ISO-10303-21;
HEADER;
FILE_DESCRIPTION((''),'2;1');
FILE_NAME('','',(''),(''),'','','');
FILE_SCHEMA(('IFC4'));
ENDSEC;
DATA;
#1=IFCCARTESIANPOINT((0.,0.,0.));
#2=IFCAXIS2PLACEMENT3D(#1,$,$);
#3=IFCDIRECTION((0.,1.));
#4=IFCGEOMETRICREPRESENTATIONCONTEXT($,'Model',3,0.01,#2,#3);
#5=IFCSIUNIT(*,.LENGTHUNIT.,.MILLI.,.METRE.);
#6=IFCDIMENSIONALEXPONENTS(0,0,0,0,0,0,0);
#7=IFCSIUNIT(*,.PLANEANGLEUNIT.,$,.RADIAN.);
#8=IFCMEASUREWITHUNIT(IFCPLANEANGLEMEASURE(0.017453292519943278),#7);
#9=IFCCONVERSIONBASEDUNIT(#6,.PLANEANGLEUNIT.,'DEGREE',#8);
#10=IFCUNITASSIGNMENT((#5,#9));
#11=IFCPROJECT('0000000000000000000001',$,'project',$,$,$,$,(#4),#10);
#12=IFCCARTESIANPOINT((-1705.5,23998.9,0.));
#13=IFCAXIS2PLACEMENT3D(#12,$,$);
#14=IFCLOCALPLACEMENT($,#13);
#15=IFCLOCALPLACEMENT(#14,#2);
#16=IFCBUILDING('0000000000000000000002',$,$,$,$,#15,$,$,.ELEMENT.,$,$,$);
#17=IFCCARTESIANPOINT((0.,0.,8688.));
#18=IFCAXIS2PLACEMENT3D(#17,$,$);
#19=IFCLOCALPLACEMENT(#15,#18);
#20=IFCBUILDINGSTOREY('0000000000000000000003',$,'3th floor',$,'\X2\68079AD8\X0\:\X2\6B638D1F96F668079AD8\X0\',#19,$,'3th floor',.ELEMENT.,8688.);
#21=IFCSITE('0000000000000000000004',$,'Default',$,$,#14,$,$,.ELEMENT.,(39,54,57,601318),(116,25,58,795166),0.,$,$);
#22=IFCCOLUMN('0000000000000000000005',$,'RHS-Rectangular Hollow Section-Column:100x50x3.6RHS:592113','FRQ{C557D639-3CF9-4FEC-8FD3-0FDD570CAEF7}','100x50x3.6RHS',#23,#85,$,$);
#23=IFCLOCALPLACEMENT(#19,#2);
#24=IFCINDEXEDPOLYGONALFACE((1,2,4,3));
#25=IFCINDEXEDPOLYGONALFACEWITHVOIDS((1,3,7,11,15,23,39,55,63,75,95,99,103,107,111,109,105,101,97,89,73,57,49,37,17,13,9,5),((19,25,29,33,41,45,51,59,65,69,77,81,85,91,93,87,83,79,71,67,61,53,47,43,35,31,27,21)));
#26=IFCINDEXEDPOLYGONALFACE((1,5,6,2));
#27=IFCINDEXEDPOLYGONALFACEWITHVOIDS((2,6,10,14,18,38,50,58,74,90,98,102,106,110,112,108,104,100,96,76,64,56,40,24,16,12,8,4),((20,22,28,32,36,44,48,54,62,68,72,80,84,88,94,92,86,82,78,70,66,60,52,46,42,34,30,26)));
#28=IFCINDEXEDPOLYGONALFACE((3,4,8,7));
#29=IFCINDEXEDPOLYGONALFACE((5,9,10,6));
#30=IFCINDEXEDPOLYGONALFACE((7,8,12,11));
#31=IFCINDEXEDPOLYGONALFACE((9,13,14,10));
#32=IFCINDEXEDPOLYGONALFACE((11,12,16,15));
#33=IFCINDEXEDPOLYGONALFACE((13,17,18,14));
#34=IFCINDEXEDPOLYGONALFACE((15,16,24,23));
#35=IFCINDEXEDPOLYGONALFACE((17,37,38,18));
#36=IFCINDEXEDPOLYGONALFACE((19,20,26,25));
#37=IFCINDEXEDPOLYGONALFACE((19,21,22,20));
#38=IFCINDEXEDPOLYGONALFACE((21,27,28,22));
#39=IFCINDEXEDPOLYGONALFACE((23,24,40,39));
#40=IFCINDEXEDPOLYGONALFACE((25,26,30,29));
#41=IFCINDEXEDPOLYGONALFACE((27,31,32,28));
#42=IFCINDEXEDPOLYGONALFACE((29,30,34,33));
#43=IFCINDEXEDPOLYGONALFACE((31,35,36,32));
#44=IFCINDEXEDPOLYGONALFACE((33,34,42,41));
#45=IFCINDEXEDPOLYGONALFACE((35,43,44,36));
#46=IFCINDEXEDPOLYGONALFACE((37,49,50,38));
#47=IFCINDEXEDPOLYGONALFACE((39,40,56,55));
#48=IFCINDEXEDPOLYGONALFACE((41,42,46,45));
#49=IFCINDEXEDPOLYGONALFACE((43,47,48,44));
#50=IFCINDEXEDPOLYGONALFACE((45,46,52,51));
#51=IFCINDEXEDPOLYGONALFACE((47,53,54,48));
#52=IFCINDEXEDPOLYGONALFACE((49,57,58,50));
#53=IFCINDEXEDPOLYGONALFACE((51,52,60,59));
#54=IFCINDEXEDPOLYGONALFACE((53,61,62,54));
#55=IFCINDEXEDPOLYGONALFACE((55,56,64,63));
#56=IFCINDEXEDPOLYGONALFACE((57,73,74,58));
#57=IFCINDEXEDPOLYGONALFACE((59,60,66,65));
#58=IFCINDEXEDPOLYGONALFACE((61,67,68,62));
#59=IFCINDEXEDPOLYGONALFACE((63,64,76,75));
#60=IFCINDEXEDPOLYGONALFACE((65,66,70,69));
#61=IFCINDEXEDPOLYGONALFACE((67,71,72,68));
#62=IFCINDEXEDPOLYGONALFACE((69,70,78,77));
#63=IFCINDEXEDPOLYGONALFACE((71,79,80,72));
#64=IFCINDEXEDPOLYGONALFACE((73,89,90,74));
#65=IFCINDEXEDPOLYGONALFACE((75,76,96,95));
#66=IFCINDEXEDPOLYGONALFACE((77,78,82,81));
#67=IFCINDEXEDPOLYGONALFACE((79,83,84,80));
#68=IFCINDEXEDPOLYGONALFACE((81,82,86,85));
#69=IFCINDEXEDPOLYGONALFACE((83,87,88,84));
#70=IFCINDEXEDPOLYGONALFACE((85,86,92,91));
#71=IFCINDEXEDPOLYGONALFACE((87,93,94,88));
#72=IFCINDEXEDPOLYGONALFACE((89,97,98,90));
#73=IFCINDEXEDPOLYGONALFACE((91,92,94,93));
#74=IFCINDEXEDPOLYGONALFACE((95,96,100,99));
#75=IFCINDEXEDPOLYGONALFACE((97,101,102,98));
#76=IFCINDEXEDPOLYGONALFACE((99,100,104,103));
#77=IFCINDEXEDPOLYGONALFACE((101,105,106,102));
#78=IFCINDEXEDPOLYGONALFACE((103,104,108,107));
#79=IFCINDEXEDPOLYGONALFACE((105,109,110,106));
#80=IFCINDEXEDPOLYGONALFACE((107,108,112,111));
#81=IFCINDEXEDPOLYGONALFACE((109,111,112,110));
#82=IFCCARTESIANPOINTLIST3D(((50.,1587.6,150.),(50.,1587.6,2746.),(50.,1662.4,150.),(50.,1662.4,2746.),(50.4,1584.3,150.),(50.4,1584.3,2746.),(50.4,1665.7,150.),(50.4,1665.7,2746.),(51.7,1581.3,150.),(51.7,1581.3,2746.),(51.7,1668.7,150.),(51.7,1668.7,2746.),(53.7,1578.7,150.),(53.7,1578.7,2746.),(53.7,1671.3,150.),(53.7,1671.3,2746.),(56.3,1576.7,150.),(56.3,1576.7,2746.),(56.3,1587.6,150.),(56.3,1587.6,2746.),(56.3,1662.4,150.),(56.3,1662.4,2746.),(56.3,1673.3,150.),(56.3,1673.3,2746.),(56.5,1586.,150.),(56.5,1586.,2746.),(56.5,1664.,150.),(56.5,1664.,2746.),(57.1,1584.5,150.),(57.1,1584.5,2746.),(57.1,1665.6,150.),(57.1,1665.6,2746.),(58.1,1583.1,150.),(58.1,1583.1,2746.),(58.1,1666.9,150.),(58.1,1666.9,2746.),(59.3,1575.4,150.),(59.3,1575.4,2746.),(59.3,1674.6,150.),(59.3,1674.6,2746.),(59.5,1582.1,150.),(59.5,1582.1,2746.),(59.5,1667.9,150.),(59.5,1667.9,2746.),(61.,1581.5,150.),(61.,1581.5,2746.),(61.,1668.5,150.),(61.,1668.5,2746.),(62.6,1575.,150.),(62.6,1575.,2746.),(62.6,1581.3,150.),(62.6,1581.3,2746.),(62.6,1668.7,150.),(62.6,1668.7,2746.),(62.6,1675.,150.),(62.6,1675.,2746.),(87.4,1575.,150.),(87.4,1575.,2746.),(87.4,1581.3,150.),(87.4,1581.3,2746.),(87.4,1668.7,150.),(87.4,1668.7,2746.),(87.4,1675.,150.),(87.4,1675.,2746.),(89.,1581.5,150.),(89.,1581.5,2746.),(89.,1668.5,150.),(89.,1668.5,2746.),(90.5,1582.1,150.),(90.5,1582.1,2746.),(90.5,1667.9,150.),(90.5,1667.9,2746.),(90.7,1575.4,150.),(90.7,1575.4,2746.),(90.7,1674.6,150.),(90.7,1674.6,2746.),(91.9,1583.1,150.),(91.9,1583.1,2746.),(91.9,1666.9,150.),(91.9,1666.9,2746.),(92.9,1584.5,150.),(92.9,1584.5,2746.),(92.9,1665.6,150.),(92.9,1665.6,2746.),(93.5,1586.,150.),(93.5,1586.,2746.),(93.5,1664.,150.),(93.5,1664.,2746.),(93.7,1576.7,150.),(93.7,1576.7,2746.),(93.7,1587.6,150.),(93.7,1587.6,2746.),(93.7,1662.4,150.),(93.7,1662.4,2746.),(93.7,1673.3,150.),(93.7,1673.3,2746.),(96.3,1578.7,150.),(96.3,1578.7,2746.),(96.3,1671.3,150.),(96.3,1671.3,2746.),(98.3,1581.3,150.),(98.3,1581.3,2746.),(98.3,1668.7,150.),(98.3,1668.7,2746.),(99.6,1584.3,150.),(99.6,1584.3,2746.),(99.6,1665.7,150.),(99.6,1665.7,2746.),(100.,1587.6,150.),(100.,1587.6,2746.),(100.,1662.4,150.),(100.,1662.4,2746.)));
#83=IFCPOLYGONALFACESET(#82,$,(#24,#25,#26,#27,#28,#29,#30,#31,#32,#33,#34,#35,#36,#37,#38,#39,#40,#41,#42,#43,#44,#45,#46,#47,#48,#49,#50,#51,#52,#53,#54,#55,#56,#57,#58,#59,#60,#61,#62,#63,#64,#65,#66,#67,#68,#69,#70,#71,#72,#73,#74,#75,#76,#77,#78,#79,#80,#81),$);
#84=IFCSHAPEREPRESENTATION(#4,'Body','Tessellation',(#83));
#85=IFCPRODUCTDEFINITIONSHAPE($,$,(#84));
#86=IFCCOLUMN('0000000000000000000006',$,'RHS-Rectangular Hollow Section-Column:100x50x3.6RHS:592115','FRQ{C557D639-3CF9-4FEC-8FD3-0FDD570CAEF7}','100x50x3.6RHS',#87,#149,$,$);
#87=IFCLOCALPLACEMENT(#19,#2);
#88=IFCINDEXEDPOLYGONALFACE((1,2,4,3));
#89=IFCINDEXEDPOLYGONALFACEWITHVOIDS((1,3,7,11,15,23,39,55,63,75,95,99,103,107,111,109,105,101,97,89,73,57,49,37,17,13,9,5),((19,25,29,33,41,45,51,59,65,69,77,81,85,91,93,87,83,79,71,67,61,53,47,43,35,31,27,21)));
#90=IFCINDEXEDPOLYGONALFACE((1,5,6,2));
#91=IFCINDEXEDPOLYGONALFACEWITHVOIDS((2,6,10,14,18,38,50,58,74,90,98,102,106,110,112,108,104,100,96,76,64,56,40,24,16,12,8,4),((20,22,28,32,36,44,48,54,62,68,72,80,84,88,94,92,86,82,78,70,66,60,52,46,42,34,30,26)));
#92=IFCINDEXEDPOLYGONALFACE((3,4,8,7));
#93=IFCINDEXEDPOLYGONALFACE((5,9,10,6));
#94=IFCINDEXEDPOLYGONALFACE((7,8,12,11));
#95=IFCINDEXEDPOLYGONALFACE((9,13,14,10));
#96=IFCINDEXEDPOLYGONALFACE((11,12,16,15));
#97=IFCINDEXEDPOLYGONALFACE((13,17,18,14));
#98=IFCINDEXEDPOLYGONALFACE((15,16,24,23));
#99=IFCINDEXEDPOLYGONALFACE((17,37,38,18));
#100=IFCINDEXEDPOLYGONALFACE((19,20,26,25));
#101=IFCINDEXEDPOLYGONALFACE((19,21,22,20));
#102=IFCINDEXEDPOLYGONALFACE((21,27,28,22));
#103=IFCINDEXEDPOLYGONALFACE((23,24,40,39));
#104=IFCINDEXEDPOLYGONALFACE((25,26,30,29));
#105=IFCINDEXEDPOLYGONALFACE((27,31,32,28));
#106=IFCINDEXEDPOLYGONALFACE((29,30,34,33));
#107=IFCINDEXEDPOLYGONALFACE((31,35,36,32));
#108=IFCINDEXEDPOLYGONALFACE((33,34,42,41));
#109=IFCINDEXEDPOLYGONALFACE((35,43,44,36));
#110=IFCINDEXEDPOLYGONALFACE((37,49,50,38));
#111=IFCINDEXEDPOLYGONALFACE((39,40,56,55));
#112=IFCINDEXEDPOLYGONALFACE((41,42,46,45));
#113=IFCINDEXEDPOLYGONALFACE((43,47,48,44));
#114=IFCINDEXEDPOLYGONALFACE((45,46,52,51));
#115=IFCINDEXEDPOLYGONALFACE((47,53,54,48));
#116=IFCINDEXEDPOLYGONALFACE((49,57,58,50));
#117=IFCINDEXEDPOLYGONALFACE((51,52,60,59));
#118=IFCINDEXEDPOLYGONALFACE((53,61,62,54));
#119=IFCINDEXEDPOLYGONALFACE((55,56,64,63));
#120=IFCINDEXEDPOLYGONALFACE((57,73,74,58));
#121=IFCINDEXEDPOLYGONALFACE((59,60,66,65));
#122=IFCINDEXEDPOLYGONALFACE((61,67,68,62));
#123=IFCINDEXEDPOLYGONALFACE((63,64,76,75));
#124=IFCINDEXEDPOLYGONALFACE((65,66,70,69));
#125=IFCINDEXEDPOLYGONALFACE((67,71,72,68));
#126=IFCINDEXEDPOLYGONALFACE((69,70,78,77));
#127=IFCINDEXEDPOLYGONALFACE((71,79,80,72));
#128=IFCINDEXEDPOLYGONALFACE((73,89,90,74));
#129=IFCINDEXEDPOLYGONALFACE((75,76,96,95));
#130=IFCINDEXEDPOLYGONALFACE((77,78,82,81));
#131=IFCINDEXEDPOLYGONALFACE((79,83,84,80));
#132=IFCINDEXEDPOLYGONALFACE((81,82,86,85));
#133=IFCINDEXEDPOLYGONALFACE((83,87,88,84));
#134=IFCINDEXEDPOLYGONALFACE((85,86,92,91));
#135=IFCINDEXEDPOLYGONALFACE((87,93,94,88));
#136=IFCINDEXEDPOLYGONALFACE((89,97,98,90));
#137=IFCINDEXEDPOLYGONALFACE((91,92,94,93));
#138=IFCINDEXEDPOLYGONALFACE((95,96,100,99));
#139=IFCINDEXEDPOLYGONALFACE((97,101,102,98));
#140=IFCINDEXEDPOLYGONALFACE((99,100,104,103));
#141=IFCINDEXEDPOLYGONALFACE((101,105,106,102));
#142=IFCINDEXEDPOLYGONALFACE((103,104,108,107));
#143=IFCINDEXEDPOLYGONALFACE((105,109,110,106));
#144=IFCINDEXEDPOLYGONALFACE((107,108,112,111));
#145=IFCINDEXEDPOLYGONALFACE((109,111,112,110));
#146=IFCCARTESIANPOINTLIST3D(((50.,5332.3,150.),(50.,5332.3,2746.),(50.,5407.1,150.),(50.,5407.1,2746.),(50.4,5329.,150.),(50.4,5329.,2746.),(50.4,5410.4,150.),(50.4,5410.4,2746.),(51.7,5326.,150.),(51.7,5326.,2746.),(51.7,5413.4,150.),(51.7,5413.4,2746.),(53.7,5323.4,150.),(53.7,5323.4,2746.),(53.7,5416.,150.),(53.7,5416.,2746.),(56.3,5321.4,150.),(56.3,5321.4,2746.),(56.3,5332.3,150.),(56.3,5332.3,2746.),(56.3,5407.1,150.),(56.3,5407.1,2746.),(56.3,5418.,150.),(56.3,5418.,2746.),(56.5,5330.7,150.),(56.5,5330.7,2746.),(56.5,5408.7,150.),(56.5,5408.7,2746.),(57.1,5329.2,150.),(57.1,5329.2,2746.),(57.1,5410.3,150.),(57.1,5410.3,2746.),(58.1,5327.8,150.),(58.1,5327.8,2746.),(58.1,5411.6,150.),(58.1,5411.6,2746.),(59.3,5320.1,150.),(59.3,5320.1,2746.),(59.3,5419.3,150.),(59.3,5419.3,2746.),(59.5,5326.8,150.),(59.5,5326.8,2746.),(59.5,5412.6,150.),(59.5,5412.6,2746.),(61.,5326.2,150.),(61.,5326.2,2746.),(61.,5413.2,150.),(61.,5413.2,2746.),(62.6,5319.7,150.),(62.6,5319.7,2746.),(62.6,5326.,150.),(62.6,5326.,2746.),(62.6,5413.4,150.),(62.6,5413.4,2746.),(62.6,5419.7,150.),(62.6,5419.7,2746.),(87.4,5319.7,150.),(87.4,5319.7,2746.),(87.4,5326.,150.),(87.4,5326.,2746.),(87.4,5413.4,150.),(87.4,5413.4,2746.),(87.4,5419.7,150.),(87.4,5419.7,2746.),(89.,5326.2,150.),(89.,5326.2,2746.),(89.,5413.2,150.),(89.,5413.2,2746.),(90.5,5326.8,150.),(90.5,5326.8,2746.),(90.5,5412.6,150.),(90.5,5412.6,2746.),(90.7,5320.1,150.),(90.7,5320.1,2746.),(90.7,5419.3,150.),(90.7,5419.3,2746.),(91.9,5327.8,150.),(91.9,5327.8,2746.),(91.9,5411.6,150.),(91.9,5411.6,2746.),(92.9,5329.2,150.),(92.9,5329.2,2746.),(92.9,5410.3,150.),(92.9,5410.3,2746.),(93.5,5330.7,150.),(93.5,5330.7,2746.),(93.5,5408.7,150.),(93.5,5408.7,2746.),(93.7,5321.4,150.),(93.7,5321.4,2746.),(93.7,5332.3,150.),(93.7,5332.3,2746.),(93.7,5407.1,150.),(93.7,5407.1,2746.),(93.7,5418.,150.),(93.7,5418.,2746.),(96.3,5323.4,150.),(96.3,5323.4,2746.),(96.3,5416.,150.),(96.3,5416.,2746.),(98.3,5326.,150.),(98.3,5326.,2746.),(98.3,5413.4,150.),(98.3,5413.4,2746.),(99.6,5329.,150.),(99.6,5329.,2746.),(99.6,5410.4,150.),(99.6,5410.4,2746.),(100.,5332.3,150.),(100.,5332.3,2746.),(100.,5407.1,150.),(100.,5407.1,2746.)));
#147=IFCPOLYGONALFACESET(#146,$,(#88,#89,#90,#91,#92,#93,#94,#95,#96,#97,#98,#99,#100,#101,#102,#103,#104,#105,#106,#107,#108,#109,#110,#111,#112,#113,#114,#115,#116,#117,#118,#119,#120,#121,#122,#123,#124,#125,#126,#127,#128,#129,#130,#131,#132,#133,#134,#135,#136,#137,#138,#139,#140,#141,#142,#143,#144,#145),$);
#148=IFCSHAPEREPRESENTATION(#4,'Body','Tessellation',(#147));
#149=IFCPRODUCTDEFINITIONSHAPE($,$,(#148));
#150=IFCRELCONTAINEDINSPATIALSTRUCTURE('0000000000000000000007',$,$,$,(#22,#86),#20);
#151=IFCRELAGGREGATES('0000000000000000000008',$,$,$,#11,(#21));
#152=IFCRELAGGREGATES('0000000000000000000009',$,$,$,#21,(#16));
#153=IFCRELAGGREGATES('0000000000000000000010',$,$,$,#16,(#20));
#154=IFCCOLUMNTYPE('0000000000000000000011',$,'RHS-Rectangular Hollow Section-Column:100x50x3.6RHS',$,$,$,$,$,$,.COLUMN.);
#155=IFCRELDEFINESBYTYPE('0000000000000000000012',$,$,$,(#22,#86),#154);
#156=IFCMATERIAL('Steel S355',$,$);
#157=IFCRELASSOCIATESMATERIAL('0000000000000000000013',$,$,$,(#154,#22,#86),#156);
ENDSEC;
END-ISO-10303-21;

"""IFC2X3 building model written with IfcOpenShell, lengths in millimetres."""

from ifc_helpers import new_model, entity, si_unit, converted_unit, point, direction, frame, frame_2d, origin, origin_2d, place, context, project, spatial, circle_curve, line_curve, trimmed, segment, composite_curve, hollow_rectangle, outline, extrude, clip, halfspace, material, type_object, element, save


model = new_model("IFC2X3")

# Units and contexts
model_context = context("Model", 3, precision=0.01, world=origin(), true_north=direction((0.0, 1.0)))
ifc_project = project(units=[si_unit("LENGTHUNIT", "METRE", prefix="MILLI"), converted_unit("PLANEANGLEUNIT", "DEGREE", entity("IfcPlaneAngleMeasure", 0.017453292519943278), si_unit("PLANEANGLEUNIT", "RADIAN"), dimensions=[0, 0, 0, 0, 0, 0, 0])], contexts=[model_context])

# Site, building, storey
site_placement = place(None, frame((-1705.5, 23998.9, 0.0)))
site = spatial("IfcSite", under=ifc_project, at=site_placement, Name="Default", CompositionType="ELEMENT", RefLatitude=(39, 54, 57, 601318), RefLongitude=(116, 25, 58, 795166), RefElevation=0.0)
building_placement = place(site_placement, origin())
building = spatial("IfcBuilding", under=site, at=building_placement, CompositionType="ELEMENT")
storey_placement = place(building_placement, frame((0.0, 0.0, 8688.0)))
storey = spatial("IfcBuildingStorey", under=building, at=storey_placement, Name="3th floor", ObjectType="标高:正负零标高", LongName="3th floor", CompositionType="ELEMENT", Elevation=8688.0)

# Columns, openings
ifc_material_1 = material(Name="Steel S355")
column_type_1 = type_object("IfcColumnType", Name="RHS-Rectangular Hollow Section-Column:100x50x3.6RHS", PredefinedType="COLUMN", material=ifc_material_1)
column_1_placement = place(storey_placement, frame((75.0, 1625.0, 2876.9)))
column_1 = element("IfcColumn", 1, at=column_1_placement, inside=storey, type_object=column_type_1, material=ifc_material_1, Name="RHS-Rectangular Hollow Section-Column:100x50x3.6RHS:592113", Description="FRQ{C557D639-3CF9-4FEC-8FD3-0FDD570CAEF7}", ObjectType="100x50x3.6RHS", context=model_context, shape_type="Clipping", body=[
    clip(clip(extrude(hollow_rectangle(XDim=50.0, YDim=100.0, WallThickness=6.3, InnerFilletRadius=6.3, OuterFilletRadius=12.6, at=origin_2d()), origin(), (0.0, 0.0, -1.0), 2782.8), halfspace(frame((-75.0, -1625.0, -2726.9), z_axis=(0.0, 0.0, 1.0), x_axis=(1.0, 0.0, 0.0)), True)), halfspace(frame((-75.0, -1625.0, -55.9), z_axis=(0.0, 0.0, -1.0), x_axis=(-1.0, 0.0, 0.0)), True)),
])
opening_1_placement = place(column_1_placement, frame((0.0, -150.1, -130.9), z_axis=(0.0, 1.0, 0.0), x_axis=(-1.0, 0.0, 0.0)))
element("IfcOpeningElement", 2, at=opening_1_placement, cuts=column_1, ObjectType="Opening", context=model_context, shape_type="SweptSolid", body=[
    extrude(outline(composite_curve([segment(trimmed(circle_curve(frame_2d((43.0, 32.0), x_axis=(1.0, 0.0)), 32.0), [point((43.0, 0.0))], [point((75.0, 32.0))], True, "CARTESIAN"), True, "CONTINUOUS"), segment(trimmed(line_curve((75.0, 32.0), (0.0, 1.0), 86.0), [point((75.0, 32.0))], [point((75.0, 118.0))], True, "CARTESIAN"), True, "CONTINUOUS"), segment(trimmed(circle_curve(frame_2d((43.0, 118.0), x_axis=(1.0, 0.0)), 32.0), [point((75.0, 118.0))], [point((43.0, 150.0))], True, "CARTESIAN"), True, "CONTINUOUS"), segment(trimmed(line_curve((43.0, 150.0), (-1.0, 0.0), 86.0), [point((43.0, 150.0))], [point((-43.0, 150.0))], True, "CARTESIAN"), True, "CONTINUOUS"), segment(trimmed(circle_curve(frame_2d((-43.0, 118.0), x_axis=(1.0, 0.0)), 32.0), [point((-43.0, 150.0))], [point((-75.0, 118.0))], True, "CARTESIAN"), True, "CONTINUOUS"), segment(trimmed(line_curve((-75.0, 118.0), (0.0, -1.0), 86.0), [point((-75.0, 118.0))], [point((-75.0, 32.0))], True, "CARTESIAN"), True, "CONTINUOUS"), segment(trimmed(circle_curve(frame_2d((-43.0, 32.0), x_axis=(1.0, 0.0)), 32.0), [point((-75.0, 32.0))], [point((-43.0, 0.0))], True, "CARTESIAN"), True, "CONTINUOUS"), segment(trimmed(line_curve((-43.0, 0.0), (1.0, 0.0), 86.0), [point((-43.0, 0.0))], [point((43.0, 0.0))], True, "CARTESIAN"), True, "CONTINUOUS")], self_intersect="UNKNOWN")), origin(), (0.0, 0.0, 1.0), 300.2),
])
column_2_placement = place(storey_placement, frame((75.0, 5369.7, 2876.9)))
column_2 = element("IfcColumn", 3, at=column_2_placement, inside=storey, type_object=column_type_1, material=ifc_material_1, Name="RHS-Rectangular Hollow Section-Column:100x50x3.6RHS:592115", Description="FRQ{C557D639-3CF9-4FEC-8FD3-0FDD570CAEF7}", ObjectType="100x50x3.6RHS", context=model_context, shape_type="Clipping", body=[
    clip(clip(extrude(hollow_rectangle(XDim=50.0, YDim=100.0, WallThickness=6.3, InnerFilletRadius=6.3, OuterFilletRadius=12.6, at=origin_2d()), origin(), (0.0, 0.0, -1.0), 2782.8), halfspace(frame((-75.0, -5369.7, -55.9), z_axis=(0.0, 0.0, -1.0), x_axis=(-1.0, 0.0, 0.0)), True)), halfspace(frame((-75.0, -5369.7, -2726.9), z_axis=(0.0, 0.0, 1.0), x_axis=(1.0, 0.0, 0.0)), True)),
])
opening_2_placement = place(column_2_placement, frame((0.0, -150.1, -130.9), z_axis=(0.0, 1.0, 0.0), x_axis=(-1.0, 0.0, 0.0)))
element("IfcOpeningElement", 4, at=opening_2_placement, cuts=column_2, ObjectType="Opening", context=model_context, shape_type="SweptSolid", body=[
    extrude(outline(composite_curve([segment(trimmed(circle_curve(frame_2d((43.0, 32.0), x_axis=(1.0, 0.0)), 32.0), [point((43.0, 0.0))], [point((75.0, 32.0))], True, "CARTESIAN"), True, "CONTINUOUS"), segment(trimmed(line_curve((75.0, 32.0), (0.0, 1.0), 86.0), [point((75.0, 32.0))], [point((75.0, 118.0))], True, "CARTESIAN"), True, "CONTINUOUS"), segment(trimmed(circle_curve(frame_2d((43.0, 118.0), x_axis=(1.0, 0.0)), 32.0), [point((75.0, 118.0))], [point((43.0, 150.0))], True, "CARTESIAN"), True, "CONTINUOUS"), segment(trimmed(line_curve((43.0, 150.0), (-1.0, 0.0), 86.0), [point((43.0, 150.0))], [point((-43.0, 150.0))], True, "CARTESIAN"), True, "CONTINUOUS"), segment(trimmed(circle_curve(frame_2d((-43.0, 118.0), x_axis=(1.0, 0.0)), 32.0), [point((-43.0, 150.0))], [point((-75.0, 118.0))], True, "CARTESIAN"), True, "CONTINUOUS"), segment(trimmed(line_curve((-75.0, 118.0), (0.0, -1.0), 86.0), [point((-75.0, 118.0))], [point((-75.0, 32.0))], True, "CARTESIAN"), True, "CONTINUOUS"), segment(trimmed(circle_curve(frame_2d((-43.0, 32.0), x_axis=(1.0, 0.0)), 32.0), [point((-75.0, 32.0))], [point((-43.0, 0.0))], True, "CARTESIAN"), True, "CONTINUOUS"), segment(trimmed(line_curve((-43.0, 0.0), (1.0, 0.0), 86.0), [point((-43.0, 0.0))], [point((43.0, 0.0))], True, "CARTESIAN"), True, "CONTINUOUS")], self_intersect="UNKNOWN")), origin(), (0.0, 0.0, 1.0), 300.2),
])

save(model, "model.ifc")
